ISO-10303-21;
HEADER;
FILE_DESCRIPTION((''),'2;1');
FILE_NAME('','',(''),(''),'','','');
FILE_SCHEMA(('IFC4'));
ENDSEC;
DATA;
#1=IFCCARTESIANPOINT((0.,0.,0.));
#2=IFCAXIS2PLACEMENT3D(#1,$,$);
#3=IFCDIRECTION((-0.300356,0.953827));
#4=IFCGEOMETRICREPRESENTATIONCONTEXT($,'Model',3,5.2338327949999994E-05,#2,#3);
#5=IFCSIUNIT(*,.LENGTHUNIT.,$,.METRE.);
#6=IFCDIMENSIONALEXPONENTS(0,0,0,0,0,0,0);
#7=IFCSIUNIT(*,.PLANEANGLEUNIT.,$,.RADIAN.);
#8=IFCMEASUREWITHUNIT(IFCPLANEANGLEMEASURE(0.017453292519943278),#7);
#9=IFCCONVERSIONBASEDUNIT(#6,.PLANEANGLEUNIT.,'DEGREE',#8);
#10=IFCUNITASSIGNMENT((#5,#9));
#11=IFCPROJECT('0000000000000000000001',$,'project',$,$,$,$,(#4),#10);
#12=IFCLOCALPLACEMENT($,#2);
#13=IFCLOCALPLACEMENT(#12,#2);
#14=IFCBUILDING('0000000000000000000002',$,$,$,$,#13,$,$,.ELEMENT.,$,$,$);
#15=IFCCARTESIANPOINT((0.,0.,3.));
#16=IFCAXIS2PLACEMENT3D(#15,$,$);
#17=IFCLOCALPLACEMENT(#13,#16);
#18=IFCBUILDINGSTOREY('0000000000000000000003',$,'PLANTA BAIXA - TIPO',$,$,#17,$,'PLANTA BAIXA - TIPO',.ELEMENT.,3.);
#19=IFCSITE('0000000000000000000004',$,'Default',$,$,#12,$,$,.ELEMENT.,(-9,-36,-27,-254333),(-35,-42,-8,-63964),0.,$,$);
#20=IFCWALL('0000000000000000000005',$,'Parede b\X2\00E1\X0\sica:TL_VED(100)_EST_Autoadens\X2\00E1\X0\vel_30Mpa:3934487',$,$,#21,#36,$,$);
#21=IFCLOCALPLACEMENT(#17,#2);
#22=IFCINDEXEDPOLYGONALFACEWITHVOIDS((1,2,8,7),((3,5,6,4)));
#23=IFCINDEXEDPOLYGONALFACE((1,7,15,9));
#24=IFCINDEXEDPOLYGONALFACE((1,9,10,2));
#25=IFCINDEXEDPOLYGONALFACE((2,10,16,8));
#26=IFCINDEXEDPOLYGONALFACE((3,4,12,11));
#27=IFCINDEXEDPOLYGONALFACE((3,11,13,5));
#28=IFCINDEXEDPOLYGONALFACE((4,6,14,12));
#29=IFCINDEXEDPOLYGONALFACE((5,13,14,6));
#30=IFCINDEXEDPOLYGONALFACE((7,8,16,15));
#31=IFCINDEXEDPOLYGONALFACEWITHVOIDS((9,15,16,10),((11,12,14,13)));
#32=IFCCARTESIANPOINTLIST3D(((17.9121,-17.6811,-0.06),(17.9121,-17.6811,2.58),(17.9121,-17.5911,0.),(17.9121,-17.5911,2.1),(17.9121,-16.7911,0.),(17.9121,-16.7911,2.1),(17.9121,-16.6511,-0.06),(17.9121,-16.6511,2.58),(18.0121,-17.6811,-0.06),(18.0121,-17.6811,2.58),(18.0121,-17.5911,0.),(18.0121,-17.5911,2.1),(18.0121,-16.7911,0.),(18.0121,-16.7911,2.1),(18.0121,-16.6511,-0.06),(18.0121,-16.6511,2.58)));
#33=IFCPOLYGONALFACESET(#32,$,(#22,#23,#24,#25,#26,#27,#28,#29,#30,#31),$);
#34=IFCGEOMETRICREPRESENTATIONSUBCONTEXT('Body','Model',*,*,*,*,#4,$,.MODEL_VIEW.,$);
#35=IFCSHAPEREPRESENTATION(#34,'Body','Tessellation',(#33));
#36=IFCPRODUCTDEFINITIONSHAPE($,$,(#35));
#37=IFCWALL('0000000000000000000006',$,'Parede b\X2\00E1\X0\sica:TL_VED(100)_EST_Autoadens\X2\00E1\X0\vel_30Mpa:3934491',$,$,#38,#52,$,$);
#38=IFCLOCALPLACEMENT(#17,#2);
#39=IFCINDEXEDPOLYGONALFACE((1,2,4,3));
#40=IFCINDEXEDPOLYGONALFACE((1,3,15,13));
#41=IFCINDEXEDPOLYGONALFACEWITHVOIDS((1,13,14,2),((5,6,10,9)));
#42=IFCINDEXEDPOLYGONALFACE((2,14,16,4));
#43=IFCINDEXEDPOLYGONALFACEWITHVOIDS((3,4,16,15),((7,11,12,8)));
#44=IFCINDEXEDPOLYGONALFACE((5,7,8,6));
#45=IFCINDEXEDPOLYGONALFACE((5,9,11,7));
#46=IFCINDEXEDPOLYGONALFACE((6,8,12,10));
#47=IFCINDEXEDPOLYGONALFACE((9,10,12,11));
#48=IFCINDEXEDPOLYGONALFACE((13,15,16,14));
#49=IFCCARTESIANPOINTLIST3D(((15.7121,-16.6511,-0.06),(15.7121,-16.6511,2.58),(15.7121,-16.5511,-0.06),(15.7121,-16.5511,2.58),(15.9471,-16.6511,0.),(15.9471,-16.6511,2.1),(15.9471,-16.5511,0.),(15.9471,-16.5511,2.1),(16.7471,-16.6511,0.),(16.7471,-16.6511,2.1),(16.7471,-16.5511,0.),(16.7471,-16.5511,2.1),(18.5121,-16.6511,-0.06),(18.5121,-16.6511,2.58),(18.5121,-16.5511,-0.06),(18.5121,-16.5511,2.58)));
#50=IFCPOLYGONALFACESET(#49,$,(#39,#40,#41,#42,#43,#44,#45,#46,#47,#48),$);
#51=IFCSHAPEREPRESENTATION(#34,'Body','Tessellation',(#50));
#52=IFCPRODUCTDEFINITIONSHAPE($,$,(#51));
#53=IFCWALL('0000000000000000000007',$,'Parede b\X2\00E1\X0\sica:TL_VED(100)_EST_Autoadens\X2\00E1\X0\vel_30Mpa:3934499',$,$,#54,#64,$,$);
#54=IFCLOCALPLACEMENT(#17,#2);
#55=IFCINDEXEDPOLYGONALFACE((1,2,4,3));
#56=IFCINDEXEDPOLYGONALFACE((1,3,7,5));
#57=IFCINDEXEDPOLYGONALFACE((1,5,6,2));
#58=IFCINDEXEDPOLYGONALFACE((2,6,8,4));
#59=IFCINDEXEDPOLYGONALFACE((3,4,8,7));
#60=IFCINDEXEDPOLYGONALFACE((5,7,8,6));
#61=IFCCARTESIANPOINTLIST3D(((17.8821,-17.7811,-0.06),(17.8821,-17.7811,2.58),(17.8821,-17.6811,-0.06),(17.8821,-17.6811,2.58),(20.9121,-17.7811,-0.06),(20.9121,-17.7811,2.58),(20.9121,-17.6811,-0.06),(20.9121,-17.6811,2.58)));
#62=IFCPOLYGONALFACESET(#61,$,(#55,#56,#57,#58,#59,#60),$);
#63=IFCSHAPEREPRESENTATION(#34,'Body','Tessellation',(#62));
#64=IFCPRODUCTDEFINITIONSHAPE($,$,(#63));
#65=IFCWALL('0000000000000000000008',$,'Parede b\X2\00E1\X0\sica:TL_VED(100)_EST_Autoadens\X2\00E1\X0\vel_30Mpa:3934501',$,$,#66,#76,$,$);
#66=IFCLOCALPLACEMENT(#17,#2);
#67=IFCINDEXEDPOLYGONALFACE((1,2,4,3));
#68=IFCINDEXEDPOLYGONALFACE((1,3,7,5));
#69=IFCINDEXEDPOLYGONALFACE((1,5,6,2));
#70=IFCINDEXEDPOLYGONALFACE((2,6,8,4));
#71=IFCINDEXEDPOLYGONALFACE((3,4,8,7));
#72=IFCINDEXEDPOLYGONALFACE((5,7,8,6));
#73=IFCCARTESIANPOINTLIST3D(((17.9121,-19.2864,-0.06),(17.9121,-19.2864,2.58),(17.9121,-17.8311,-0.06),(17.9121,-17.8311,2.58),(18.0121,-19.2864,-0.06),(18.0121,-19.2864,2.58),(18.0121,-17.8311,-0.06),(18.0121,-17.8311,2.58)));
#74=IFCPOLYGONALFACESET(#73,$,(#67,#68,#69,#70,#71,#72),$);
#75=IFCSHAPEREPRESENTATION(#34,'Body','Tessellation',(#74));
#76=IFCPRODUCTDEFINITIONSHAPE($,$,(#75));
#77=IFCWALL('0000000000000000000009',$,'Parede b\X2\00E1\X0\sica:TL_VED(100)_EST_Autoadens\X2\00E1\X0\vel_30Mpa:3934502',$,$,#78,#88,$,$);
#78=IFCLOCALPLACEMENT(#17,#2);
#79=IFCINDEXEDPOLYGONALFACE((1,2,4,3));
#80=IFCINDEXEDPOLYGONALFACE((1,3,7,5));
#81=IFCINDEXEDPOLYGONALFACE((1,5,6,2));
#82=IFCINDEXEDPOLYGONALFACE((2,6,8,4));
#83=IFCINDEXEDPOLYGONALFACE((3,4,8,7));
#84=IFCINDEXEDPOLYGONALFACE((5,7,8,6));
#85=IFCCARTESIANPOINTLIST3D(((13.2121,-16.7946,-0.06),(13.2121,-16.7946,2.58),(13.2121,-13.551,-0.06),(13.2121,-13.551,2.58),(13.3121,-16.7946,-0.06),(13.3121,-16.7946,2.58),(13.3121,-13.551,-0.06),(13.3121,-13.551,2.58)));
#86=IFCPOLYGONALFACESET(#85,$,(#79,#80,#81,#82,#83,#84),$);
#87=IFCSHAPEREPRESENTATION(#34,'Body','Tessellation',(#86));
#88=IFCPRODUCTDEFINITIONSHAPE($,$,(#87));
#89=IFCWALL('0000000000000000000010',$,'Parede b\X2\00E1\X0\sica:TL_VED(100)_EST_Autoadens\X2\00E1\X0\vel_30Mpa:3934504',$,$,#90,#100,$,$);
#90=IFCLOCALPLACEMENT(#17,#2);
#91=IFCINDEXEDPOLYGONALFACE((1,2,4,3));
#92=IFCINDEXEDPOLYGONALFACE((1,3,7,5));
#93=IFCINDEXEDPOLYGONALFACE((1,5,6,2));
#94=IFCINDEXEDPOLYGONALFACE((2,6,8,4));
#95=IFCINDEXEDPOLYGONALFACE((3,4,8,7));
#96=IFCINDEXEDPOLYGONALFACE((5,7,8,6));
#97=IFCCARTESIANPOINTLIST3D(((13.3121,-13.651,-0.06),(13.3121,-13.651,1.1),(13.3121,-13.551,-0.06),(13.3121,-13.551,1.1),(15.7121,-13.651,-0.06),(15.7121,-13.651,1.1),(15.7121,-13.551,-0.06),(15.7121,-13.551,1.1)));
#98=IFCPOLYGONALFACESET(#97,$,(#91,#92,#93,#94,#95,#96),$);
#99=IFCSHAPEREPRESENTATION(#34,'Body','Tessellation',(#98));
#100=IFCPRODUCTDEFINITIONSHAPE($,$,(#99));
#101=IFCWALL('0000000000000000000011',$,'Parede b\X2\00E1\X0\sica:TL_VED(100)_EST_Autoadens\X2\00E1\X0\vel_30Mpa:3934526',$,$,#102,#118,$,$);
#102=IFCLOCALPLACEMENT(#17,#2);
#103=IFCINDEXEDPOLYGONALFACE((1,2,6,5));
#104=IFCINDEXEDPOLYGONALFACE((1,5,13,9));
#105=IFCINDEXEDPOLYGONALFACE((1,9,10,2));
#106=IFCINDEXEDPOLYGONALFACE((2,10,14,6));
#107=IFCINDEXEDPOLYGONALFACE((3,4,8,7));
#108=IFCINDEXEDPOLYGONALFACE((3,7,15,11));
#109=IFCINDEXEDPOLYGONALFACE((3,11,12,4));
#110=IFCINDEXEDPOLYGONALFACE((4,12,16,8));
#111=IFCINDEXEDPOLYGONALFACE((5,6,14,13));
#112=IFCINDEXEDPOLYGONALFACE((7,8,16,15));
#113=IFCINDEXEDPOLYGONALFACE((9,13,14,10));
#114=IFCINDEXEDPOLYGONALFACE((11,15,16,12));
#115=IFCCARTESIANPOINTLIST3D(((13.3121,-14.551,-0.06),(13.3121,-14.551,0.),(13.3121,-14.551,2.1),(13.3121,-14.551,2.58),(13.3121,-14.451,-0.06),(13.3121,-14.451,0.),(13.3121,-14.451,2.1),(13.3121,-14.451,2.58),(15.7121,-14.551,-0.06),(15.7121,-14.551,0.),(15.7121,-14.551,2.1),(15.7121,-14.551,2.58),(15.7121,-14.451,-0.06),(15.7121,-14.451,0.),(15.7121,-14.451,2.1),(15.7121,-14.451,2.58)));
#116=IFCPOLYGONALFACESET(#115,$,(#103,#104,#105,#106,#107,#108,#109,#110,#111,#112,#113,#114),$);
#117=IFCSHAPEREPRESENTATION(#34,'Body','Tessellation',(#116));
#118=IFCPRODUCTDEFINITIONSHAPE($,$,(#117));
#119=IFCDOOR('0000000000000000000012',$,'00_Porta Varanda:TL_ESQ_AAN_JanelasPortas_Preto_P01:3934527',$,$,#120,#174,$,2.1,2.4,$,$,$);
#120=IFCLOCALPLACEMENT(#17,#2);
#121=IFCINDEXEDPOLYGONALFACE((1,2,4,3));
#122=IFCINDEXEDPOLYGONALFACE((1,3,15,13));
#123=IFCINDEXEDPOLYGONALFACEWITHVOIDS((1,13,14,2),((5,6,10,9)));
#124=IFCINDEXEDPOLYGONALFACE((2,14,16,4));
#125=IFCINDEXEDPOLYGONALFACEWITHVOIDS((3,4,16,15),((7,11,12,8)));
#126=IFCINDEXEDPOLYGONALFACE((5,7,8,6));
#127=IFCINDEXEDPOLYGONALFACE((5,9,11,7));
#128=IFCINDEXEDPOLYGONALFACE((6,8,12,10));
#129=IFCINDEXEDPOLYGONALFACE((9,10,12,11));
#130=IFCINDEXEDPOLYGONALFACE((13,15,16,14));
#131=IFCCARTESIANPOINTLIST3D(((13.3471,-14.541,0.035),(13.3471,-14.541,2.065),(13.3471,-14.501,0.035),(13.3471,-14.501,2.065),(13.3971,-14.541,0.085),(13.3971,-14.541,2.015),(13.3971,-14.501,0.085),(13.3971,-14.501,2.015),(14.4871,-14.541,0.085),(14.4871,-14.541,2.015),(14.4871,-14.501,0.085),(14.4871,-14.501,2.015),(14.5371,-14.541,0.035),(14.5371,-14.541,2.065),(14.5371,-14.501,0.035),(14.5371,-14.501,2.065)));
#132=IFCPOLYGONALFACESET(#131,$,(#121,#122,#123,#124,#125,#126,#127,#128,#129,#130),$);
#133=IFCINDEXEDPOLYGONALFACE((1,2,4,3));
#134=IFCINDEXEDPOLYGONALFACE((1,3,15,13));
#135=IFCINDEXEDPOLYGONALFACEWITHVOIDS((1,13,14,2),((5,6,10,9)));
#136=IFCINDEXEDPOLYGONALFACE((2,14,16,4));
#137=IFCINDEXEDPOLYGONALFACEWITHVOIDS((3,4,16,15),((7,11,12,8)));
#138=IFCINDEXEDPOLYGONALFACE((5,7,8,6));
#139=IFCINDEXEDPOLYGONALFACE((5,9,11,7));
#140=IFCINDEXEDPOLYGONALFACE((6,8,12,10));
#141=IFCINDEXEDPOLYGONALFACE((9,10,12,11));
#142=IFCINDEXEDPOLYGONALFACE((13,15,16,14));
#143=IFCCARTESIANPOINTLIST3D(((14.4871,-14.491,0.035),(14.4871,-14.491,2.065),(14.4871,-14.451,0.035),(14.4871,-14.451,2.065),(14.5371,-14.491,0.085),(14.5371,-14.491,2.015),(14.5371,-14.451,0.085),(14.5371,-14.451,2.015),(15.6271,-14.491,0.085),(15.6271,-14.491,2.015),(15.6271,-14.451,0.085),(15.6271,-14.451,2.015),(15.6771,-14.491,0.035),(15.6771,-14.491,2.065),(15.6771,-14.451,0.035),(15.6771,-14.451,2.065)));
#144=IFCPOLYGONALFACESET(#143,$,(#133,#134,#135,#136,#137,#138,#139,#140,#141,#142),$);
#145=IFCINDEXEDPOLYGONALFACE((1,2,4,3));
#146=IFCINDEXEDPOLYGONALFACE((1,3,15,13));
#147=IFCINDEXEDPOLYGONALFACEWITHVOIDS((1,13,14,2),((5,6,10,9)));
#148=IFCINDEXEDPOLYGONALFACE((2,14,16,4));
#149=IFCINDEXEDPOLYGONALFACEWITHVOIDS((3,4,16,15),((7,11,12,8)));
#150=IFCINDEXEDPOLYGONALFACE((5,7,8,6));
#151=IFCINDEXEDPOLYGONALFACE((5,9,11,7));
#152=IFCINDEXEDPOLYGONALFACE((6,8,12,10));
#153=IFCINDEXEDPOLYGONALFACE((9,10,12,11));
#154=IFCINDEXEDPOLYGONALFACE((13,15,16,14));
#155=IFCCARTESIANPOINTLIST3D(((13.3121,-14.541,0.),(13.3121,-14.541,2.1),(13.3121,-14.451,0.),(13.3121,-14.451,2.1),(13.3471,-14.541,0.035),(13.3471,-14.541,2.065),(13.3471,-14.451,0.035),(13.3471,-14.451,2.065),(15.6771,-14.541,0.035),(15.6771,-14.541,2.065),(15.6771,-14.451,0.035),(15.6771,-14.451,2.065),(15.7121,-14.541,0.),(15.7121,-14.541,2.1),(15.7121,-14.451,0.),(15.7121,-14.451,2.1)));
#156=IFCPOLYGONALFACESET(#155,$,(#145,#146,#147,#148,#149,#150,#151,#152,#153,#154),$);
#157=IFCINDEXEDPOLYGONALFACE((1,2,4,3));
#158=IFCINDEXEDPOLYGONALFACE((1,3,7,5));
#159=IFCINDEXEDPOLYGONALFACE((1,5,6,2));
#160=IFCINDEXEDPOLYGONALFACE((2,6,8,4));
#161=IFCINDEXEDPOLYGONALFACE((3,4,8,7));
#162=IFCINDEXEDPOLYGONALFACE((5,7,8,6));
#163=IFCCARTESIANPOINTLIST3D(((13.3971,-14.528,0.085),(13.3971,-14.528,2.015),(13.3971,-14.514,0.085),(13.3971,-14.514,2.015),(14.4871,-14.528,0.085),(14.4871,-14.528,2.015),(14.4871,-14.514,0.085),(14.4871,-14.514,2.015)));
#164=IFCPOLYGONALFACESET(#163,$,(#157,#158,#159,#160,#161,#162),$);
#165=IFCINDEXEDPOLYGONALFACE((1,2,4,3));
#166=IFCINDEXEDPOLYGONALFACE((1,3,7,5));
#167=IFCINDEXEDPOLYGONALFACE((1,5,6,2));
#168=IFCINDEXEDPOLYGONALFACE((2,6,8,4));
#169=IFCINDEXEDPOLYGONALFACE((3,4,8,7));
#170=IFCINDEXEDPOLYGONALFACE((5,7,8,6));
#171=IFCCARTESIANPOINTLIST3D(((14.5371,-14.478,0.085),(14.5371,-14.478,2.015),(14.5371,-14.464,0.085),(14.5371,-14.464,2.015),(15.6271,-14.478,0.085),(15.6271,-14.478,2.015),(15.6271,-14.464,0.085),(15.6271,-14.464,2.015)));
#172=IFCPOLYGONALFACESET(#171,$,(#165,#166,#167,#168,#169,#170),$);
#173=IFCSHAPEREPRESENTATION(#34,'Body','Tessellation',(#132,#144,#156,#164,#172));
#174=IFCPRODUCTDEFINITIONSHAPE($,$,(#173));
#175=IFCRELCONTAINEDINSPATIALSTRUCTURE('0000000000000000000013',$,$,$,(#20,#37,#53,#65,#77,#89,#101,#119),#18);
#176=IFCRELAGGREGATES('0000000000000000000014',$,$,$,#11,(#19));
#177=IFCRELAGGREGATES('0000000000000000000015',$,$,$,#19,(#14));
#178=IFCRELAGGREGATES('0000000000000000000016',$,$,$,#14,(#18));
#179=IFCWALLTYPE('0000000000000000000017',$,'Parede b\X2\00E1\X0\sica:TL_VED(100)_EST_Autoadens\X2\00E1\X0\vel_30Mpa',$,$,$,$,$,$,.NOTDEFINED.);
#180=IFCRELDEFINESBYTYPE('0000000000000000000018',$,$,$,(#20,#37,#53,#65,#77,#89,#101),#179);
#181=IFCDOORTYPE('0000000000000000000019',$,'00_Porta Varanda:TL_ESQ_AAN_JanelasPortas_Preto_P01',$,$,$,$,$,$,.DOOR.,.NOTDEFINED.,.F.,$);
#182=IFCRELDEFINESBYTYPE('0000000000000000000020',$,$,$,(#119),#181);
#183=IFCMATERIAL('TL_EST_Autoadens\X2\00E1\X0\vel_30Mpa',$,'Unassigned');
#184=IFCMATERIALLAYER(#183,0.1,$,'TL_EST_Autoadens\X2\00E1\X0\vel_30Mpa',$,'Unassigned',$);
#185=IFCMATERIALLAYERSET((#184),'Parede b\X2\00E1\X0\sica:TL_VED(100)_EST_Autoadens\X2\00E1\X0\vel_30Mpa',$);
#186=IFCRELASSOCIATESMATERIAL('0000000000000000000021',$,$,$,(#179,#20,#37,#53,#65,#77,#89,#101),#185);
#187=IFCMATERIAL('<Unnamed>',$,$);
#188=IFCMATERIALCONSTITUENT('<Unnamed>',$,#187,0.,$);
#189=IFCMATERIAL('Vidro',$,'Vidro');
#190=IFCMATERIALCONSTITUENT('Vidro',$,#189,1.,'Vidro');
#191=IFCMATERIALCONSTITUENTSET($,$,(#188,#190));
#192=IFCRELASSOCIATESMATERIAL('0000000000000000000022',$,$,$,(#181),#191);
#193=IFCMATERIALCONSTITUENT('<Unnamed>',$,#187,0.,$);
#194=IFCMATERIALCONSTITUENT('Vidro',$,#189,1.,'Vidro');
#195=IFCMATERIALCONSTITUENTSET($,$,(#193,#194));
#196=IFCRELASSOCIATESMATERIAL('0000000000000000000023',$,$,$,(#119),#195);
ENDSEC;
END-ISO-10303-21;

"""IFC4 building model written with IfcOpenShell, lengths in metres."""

from ifc_helpers import new_model, entity, si_unit, converted_unit, direction, frame, frame_2d, origin, place, context, subcontext, project, spatial, polyline, rectangle, outline, extrude, source, transform, mapped, material, layer, layer_set, layer_usage, constituent, constituent_set, type_object, type_shapes, element, fill, save


model = new_model("IFC4")

# Units and contexts
model_context = context("Model", 3, precision=5.2338327949999994e-05, world=origin(), true_north=direction((-0.300356, 0.953827)))
body_context = subcontext(model_context, "Body", "Model", "MODEL_VIEW")
ifc_project = project(units=[si_unit("LENGTHUNIT", "METRE"), converted_unit("PLANEANGLEUNIT", "DEGREE", entity("IfcPlaneAngleMeasure", 0.017453292519943278), si_unit("PLANEANGLEUNIT", "RADIAN"), dimensions=[0, 0, 0, 0, 0, 0, 0])], contexts=[model_context])

# Site, building, storey
site_placement = place(None, origin())
site = spatial("IfcSite", under=ifc_project, at=site_placement, Name="Default", CompositionType="ELEMENT", RefLatitude=(-9, -36, -27, -254333), RefLongitude=(-35, -42, -8, -63964), RefElevation=0.0)
building_placement = place(site_placement, origin())
building = spatial("IfcBuilding", under=site, at=building_placement, CompositionType="ELEMENT")
storey_placement = place(building_placement, frame((0.0, 0.0, 3.0)))
storey = spatial("IfcBuildingStorey", under=building, at=storey_placement, Name="PLANTA BAIXA - TIPO", LongName="PLANTA BAIXA - TIPO", CompositionType="ELEMENT", Elevation=3.0)

# Walls, openings
ifc_material_1 = material(Name="TL_EST_Autoadensável_30Mpa", Category="Unassigned")
ifc_layer_1 = layer(ifc_material_1, 0.1, Name="TL_EST_Autoadensável_30Mpa", Category="Unassigned")
ifc_layer_set_1 = layer_set([ifc_layer_1], Name="Parede básica:TL_VED(100)_EST_Autoadensável_30Mpa")
ifc_layer_usage_1 = layer_usage(ifc_layer_set_1, "AXIS2", "NEGATIVE", 0.05)
wall_type_1 = type_object("IfcWallType", Name="Parede básica:TL_VED(100)_EST_Autoadensável_30Mpa", PredefinedType="NOTDEFINED", material=ifc_layer_set_1)
wall_1_placement = place(storey_placement, frame((17.9621, -16.6511, -0.06), z_axis=(0.0, 0.0, 1.0), x_axis=(0.0, -1.0, 0.0)))
wall_1 = element("IfcWall", 1, at=wall_1_placement, inside=storey, type_object=wall_type_1, material=ifc_layer_usage_1, Name="Parede básica:TL_VED(100)_EST_Autoadensável_30Mpa:3934487", context=body_context, shape_type="SweptSolid", body=[
    extrude(rectangle(XDim=1.03, YDim=0.1, at=frame_2d((0.515, 0.0), x_axis=(-1.0, 0.0))), origin(), (0.0, 0.0, 1.0), 2.64),
])
opening_1_placement = place(wall_1_placement, frame((0.14, -0.05, 0.06)))
element("IfcOpeningElement", 2, at=opening_1_placement, cuts=wall_1, PredefinedType="OPENING", context=body_context, shape_type="SweptSolid", body=[
    extrude(rectangle(XDim=2.1, YDim=0.8, at=frame_2d((1.05, 0.4), x_axis=(1.0, 0.0))), frame((0.0, 0.0, 0.0), z_axis=(0.0, 1.0, 0.0), x_axis=(0.0, 0.0, 1.0)), (0.0, 0.0, 1.0), 0.1),
])
ifc_layer_usage_2 = layer_usage(ifc_layer_set_1, "AXIS2", "NEGATIVE", 0.05)
wall_2_placement = place(storey_placement, frame((15.7121, -16.6011, -0.06)))
wall_2 = element("IfcWall", 3, at=wall_2_placement, inside=storey, type_object=wall_type_1, material=ifc_layer_usage_2, Name="Parede básica:TL_VED(100)_EST_Autoadensável_30Mpa:3934491", context=body_context, shape_type="SweptSolid", body=[
    extrude(rectangle(XDim=2.8, YDim=0.1, at=frame_2d((1.4, 0.0), x_axis=(-1.0, 0.0))), origin(), (0.0, 0.0, 1.0), 2.64),
])
opening_2_placement = place(wall_2_placement, frame((0.235, -0.05, 0.06)))
element("IfcOpeningElement", 4, at=opening_2_placement, cuts=wall_2, PredefinedType="OPENING", context=body_context, shape_type="SweptSolid", body=[
    extrude(rectangle(XDim=2.1, YDim=0.8, at=frame_2d((1.05, 0.4), x_axis=(1.0, 0.0))), frame((0.0, 0.0, 0.0), z_axis=(0.0, 1.0, 0.0), x_axis=(0.0, 0.0, 1.0)), (0.0, 0.0, 1.0), 0.1),
])

# Walls
ifc_layer_usage_3 = layer_usage(ifc_layer_set_1, "AXIS2", "POSITIVE", -0.05)
wall_3_placement = place(storey_placement, frame((17.8821, -17.7311, -0.06)))
element("IfcWall", 5, at=wall_3_placement, inside=storey, type_object=wall_type_1, material=ifc_layer_usage_3, Name="Parede básica:TL_VED(100)_EST_Autoadensável_30Mpa:3934499", context=body_context, shape_type="SweptSolid", body=[
    extrude(rectangle(XDim=3.03, YDim=0.1, at=frame_2d((1.515, 0.0), x_axis=(-1.0, 0.0))), origin(), (0.0, 0.0, 1.0), 2.64),
])
ifc_layer_usage_4 = layer_usage(ifc_layer_set_1, "AXIS2", "NEGATIVE", 0.05)
wall_4_placement = place(storey_placement, frame((17.9621, -19.2864, -0.06), z_axis=(0.0, 0.0, 1.0), x_axis=(0.0, 1.0, 0.0)))
element("IfcWall", 6, at=wall_4_placement, inside=storey, type_object=wall_type_1, material=ifc_layer_usage_4, Name="Parede básica:TL_VED(100)_EST_Autoadensável_30Mpa:3934501", context=body_context, shape_type="SweptSolid", body=[
    extrude(rectangle(XDim=1.4552, YDim=0.1, at=frame_2d((0.7276, 0.0), x_axis=(-1.0, 0.0))), origin(), (0.0, 0.0, 1.0), 2.64),
])
ifc_layer_usage_5 = layer_usage(ifc_layer_set_1, "AXIS2", "POSITIVE", -0.05)
wall_5_placement = place(storey_placement, frame((13.2621, -13.551, -0.06), z_axis=(0.0, 0.0, 1.0), x_axis=(0.0, -1.0, 0.0)))
element("IfcWall", 7, at=wall_5_placement, inside=storey, type_object=wall_type_1, material=ifc_layer_usage_5, Name="Parede básica:TL_VED(100)_EST_Autoadensável_30Mpa:3934502", context=body_context, shape_type="SweptSolid", body=[
    extrude(rectangle(XDim=3.2437, YDim=0.1, at=frame_2d((1.6218, 0.0), x_axis=(-1.0, 0.0))), origin(), (0.0, 0.0, 1.0), 2.64),
])

# Wall
ifc_layer_usage_6 = layer_usage(ifc_layer_set_1, "AXIS2", "POSITIVE", -0.05)
wall_6_placement = place(storey_placement, frame((15.7121, -13.601, -0.06), z_axis=(0.0, 0.0, 1.0), x_axis=(-1.0, 0.0, 0.0)))
element("IfcWall", 8, at=wall_6_placement, inside=storey, type_object=wall_type_1, material=ifc_layer_usage_6, Name="Parede básica:TL_VED(100)_EST_Autoadensável_30Mpa:3934504", context=body_context, shape_type="SweptSolid", body=[
    extrude(rectangle(XDim=2.4, YDim=0.1, at=frame_2d((1.2, 0.0), x_axis=(-1.0, 0.0))), origin(), (0.0, 0.0, 1.0), 1.16),
])

# Wall, opening, door
ifc_layer_usage_7 = layer_usage(ifc_layer_set_1, "AXIS2", "POSITIVE", -0.05)
wall_7_placement = place(storey_placement, frame((15.7121, -14.501, -0.06), z_axis=(0.0, 0.0, 1.0), x_axis=(-1.0, 0.0, 0.0)))
wall_7 = element("IfcWall", 9, at=wall_7_placement, inside=storey, type_object=wall_type_1, material=ifc_layer_usage_7, Name="Parede básica:TL_VED(100)_EST_Autoadensável_30Mpa:3934526", context=body_context, shape_type="SweptSolid", body=[
    extrude(rectangle(XDim=2.4, YDim=0.1, at=frame_2d((1.2, 0.0), x_axis=(-1.0, 0.0))), origin(), (0.0, 0.0, 1.0), 2.64),
])
opening_3_placement = place(wall_7_placement, frame((0.0, -0.05, 0.06)))
opening_3 = element("IfcOpeningElement", 10, at=opening_3_placement, cuts=wall_7, PredefinedType="OPENING", context=body_context, shape_type="SweptSolid", body=[
    extrude(rectangle(XDim=2.1, YDim=2.4, at=frame_2d((1.05, 1.2), x_axis=(1.0, 0.0))), frame((0.0, 0.0, 0.0), z_axis=(0.0, 1.0, 0.0), x_axis=(0.0, 0.0, 1.0)), (0.0, 0.0, 1.0), 0.1),
])
ifc_material_2 = material(Name="<Unnamed>")
ifc_constituent_1 = constituent(ifc_material_2, Name="<Unnamed>", fraction=0.0)
ifc_material_3 = material(Name="Vidro", Category="Vidro")
ifc_constituent_2 = constituent(ifc_material_3, Name="Vidro", Category="Vidro", fraction=1.0)
ifc_constituent_set_1 = constituent_set(constituents=[ifc_constituent_1, ifc_constituent_2])
ifc_constituent_3 = constituent(ifc_material_2, Name="<Unnamed>", fraction=0.0)
ifc_constituent_4 = constituent(ifc_material_3, Name="Vidro", Category="Vidro", fraction=1.0)
ifc_constituent_set_2 = constituent_set(constituents=[ifc_constituent_3, ifc_constituent_4])
door_type = type_object("IfcDoorType", Name="00_Porta Varanda:TL_ESQ_AAN_JanelasPortas_Preto_P01", OperationType="NOTDEFINED", ParameterTakesPrecedence=False, PredefinedType="DOOR", material=ifc_constituent_set_2)
shared_shape = source(origin(), body_context, "Body", "SweptSolid", [
    extrude(outline(polyline([(-1.015, -0.595), (1.015, -0.595), (1.015, 0.595), (-1.015, 0.595), (-1.015, -0.595)]), holes=[polyline([(0.965, -0.545), (-0.965, -0.545), (-0.965, 0.545), (0.965, 0.545), (0.965, -0.545)])]), frame((1.77, 0.05, 1.05), z_axis=(0.0, 1.0, 0.0), x_axis=(0.0, 0.0, 1.0)), (0.0, 0.0, 1.0), 0.04),
    extrude(outline(polyline([(-1.015, -0.595), (1.015, -0.595), (1.015, 0.595), (-1.015, 0.595), (-1.015, -0.595)]), holes=[polyline([(0.965, -0.545), (-0.965, -0.545), (-0.965, 0.545), (0.965, 0.545), (0.965, -0.545)])]), frame((0.63, 0.0, 1.05), z_axis=(0.0, 1.0, 0.0), x_axis=(0.0, 0.0, -1.0)), (0.0, 0.0, 1.0), 0.04),
    extrude(outline(polyline([(-1.05, -1.2), (1.05, -1.2), (1.05, 1.2), (-1.05, 1.2), (-1.05, -1.2)]), holes=[polyline([(1.015, -1.165), (-1.015, -1.165), (-1.015, 1.165), (1.015, 1.165), (1.015, -1.165)])]), frame((1.2, 0.0, 1.05), z_axis=(0.0, 1.0, 0.0), x_axis=(0.0, 0.0, -1.0)), (0.0, 0.0, 1.0), 0.09),
    extrude(rectangle(XDim=0.014, YDim=1.09, at=frame_2d((0.0, 0.0), x_axis=(1.0, 0.0))), frame((1.77, 0.07, 0.085), z_axis=(0.0, 0.0, 1.0), x_axis=(0.0, -1.0, 0.0)), (0.0, 0.0, 1.0), 1.93),
    extrude(rectangle(XDim=0.014, YDim=1.09, at=frame_2d((0.0, 0.0), x_axis=(1.0, 0.0))), frame((0.63, 0.02, 0.085), z_axis=(0.0, 0.0, 1.0), x_axis=(0.0, -1.0, 0.0)), (0.0, 0.0, 1.0), 1.93),
])
type_shapes(door_type, [shared_shape])
door_placement = place(opening_3_placement, origin())
door = element("IfcDoor", 11, at=door_placement, inside=storey, type_object=door_type, material=ifc_constituent_set_1, Name="00_Porta Varanda:TL_ESQ_AAN_JanelasPortas_Preto_P01:3934527", OverallHeight=2.1, OverallWidth=2.4, context=body_context, shape_type="MappedRepresentation", body=[
    mapped(shared_shape, transform((0.0, 0.0, 0.0), scale=1.0)),
])
fill(opening_3, door)

save(model, "model.ifc")
